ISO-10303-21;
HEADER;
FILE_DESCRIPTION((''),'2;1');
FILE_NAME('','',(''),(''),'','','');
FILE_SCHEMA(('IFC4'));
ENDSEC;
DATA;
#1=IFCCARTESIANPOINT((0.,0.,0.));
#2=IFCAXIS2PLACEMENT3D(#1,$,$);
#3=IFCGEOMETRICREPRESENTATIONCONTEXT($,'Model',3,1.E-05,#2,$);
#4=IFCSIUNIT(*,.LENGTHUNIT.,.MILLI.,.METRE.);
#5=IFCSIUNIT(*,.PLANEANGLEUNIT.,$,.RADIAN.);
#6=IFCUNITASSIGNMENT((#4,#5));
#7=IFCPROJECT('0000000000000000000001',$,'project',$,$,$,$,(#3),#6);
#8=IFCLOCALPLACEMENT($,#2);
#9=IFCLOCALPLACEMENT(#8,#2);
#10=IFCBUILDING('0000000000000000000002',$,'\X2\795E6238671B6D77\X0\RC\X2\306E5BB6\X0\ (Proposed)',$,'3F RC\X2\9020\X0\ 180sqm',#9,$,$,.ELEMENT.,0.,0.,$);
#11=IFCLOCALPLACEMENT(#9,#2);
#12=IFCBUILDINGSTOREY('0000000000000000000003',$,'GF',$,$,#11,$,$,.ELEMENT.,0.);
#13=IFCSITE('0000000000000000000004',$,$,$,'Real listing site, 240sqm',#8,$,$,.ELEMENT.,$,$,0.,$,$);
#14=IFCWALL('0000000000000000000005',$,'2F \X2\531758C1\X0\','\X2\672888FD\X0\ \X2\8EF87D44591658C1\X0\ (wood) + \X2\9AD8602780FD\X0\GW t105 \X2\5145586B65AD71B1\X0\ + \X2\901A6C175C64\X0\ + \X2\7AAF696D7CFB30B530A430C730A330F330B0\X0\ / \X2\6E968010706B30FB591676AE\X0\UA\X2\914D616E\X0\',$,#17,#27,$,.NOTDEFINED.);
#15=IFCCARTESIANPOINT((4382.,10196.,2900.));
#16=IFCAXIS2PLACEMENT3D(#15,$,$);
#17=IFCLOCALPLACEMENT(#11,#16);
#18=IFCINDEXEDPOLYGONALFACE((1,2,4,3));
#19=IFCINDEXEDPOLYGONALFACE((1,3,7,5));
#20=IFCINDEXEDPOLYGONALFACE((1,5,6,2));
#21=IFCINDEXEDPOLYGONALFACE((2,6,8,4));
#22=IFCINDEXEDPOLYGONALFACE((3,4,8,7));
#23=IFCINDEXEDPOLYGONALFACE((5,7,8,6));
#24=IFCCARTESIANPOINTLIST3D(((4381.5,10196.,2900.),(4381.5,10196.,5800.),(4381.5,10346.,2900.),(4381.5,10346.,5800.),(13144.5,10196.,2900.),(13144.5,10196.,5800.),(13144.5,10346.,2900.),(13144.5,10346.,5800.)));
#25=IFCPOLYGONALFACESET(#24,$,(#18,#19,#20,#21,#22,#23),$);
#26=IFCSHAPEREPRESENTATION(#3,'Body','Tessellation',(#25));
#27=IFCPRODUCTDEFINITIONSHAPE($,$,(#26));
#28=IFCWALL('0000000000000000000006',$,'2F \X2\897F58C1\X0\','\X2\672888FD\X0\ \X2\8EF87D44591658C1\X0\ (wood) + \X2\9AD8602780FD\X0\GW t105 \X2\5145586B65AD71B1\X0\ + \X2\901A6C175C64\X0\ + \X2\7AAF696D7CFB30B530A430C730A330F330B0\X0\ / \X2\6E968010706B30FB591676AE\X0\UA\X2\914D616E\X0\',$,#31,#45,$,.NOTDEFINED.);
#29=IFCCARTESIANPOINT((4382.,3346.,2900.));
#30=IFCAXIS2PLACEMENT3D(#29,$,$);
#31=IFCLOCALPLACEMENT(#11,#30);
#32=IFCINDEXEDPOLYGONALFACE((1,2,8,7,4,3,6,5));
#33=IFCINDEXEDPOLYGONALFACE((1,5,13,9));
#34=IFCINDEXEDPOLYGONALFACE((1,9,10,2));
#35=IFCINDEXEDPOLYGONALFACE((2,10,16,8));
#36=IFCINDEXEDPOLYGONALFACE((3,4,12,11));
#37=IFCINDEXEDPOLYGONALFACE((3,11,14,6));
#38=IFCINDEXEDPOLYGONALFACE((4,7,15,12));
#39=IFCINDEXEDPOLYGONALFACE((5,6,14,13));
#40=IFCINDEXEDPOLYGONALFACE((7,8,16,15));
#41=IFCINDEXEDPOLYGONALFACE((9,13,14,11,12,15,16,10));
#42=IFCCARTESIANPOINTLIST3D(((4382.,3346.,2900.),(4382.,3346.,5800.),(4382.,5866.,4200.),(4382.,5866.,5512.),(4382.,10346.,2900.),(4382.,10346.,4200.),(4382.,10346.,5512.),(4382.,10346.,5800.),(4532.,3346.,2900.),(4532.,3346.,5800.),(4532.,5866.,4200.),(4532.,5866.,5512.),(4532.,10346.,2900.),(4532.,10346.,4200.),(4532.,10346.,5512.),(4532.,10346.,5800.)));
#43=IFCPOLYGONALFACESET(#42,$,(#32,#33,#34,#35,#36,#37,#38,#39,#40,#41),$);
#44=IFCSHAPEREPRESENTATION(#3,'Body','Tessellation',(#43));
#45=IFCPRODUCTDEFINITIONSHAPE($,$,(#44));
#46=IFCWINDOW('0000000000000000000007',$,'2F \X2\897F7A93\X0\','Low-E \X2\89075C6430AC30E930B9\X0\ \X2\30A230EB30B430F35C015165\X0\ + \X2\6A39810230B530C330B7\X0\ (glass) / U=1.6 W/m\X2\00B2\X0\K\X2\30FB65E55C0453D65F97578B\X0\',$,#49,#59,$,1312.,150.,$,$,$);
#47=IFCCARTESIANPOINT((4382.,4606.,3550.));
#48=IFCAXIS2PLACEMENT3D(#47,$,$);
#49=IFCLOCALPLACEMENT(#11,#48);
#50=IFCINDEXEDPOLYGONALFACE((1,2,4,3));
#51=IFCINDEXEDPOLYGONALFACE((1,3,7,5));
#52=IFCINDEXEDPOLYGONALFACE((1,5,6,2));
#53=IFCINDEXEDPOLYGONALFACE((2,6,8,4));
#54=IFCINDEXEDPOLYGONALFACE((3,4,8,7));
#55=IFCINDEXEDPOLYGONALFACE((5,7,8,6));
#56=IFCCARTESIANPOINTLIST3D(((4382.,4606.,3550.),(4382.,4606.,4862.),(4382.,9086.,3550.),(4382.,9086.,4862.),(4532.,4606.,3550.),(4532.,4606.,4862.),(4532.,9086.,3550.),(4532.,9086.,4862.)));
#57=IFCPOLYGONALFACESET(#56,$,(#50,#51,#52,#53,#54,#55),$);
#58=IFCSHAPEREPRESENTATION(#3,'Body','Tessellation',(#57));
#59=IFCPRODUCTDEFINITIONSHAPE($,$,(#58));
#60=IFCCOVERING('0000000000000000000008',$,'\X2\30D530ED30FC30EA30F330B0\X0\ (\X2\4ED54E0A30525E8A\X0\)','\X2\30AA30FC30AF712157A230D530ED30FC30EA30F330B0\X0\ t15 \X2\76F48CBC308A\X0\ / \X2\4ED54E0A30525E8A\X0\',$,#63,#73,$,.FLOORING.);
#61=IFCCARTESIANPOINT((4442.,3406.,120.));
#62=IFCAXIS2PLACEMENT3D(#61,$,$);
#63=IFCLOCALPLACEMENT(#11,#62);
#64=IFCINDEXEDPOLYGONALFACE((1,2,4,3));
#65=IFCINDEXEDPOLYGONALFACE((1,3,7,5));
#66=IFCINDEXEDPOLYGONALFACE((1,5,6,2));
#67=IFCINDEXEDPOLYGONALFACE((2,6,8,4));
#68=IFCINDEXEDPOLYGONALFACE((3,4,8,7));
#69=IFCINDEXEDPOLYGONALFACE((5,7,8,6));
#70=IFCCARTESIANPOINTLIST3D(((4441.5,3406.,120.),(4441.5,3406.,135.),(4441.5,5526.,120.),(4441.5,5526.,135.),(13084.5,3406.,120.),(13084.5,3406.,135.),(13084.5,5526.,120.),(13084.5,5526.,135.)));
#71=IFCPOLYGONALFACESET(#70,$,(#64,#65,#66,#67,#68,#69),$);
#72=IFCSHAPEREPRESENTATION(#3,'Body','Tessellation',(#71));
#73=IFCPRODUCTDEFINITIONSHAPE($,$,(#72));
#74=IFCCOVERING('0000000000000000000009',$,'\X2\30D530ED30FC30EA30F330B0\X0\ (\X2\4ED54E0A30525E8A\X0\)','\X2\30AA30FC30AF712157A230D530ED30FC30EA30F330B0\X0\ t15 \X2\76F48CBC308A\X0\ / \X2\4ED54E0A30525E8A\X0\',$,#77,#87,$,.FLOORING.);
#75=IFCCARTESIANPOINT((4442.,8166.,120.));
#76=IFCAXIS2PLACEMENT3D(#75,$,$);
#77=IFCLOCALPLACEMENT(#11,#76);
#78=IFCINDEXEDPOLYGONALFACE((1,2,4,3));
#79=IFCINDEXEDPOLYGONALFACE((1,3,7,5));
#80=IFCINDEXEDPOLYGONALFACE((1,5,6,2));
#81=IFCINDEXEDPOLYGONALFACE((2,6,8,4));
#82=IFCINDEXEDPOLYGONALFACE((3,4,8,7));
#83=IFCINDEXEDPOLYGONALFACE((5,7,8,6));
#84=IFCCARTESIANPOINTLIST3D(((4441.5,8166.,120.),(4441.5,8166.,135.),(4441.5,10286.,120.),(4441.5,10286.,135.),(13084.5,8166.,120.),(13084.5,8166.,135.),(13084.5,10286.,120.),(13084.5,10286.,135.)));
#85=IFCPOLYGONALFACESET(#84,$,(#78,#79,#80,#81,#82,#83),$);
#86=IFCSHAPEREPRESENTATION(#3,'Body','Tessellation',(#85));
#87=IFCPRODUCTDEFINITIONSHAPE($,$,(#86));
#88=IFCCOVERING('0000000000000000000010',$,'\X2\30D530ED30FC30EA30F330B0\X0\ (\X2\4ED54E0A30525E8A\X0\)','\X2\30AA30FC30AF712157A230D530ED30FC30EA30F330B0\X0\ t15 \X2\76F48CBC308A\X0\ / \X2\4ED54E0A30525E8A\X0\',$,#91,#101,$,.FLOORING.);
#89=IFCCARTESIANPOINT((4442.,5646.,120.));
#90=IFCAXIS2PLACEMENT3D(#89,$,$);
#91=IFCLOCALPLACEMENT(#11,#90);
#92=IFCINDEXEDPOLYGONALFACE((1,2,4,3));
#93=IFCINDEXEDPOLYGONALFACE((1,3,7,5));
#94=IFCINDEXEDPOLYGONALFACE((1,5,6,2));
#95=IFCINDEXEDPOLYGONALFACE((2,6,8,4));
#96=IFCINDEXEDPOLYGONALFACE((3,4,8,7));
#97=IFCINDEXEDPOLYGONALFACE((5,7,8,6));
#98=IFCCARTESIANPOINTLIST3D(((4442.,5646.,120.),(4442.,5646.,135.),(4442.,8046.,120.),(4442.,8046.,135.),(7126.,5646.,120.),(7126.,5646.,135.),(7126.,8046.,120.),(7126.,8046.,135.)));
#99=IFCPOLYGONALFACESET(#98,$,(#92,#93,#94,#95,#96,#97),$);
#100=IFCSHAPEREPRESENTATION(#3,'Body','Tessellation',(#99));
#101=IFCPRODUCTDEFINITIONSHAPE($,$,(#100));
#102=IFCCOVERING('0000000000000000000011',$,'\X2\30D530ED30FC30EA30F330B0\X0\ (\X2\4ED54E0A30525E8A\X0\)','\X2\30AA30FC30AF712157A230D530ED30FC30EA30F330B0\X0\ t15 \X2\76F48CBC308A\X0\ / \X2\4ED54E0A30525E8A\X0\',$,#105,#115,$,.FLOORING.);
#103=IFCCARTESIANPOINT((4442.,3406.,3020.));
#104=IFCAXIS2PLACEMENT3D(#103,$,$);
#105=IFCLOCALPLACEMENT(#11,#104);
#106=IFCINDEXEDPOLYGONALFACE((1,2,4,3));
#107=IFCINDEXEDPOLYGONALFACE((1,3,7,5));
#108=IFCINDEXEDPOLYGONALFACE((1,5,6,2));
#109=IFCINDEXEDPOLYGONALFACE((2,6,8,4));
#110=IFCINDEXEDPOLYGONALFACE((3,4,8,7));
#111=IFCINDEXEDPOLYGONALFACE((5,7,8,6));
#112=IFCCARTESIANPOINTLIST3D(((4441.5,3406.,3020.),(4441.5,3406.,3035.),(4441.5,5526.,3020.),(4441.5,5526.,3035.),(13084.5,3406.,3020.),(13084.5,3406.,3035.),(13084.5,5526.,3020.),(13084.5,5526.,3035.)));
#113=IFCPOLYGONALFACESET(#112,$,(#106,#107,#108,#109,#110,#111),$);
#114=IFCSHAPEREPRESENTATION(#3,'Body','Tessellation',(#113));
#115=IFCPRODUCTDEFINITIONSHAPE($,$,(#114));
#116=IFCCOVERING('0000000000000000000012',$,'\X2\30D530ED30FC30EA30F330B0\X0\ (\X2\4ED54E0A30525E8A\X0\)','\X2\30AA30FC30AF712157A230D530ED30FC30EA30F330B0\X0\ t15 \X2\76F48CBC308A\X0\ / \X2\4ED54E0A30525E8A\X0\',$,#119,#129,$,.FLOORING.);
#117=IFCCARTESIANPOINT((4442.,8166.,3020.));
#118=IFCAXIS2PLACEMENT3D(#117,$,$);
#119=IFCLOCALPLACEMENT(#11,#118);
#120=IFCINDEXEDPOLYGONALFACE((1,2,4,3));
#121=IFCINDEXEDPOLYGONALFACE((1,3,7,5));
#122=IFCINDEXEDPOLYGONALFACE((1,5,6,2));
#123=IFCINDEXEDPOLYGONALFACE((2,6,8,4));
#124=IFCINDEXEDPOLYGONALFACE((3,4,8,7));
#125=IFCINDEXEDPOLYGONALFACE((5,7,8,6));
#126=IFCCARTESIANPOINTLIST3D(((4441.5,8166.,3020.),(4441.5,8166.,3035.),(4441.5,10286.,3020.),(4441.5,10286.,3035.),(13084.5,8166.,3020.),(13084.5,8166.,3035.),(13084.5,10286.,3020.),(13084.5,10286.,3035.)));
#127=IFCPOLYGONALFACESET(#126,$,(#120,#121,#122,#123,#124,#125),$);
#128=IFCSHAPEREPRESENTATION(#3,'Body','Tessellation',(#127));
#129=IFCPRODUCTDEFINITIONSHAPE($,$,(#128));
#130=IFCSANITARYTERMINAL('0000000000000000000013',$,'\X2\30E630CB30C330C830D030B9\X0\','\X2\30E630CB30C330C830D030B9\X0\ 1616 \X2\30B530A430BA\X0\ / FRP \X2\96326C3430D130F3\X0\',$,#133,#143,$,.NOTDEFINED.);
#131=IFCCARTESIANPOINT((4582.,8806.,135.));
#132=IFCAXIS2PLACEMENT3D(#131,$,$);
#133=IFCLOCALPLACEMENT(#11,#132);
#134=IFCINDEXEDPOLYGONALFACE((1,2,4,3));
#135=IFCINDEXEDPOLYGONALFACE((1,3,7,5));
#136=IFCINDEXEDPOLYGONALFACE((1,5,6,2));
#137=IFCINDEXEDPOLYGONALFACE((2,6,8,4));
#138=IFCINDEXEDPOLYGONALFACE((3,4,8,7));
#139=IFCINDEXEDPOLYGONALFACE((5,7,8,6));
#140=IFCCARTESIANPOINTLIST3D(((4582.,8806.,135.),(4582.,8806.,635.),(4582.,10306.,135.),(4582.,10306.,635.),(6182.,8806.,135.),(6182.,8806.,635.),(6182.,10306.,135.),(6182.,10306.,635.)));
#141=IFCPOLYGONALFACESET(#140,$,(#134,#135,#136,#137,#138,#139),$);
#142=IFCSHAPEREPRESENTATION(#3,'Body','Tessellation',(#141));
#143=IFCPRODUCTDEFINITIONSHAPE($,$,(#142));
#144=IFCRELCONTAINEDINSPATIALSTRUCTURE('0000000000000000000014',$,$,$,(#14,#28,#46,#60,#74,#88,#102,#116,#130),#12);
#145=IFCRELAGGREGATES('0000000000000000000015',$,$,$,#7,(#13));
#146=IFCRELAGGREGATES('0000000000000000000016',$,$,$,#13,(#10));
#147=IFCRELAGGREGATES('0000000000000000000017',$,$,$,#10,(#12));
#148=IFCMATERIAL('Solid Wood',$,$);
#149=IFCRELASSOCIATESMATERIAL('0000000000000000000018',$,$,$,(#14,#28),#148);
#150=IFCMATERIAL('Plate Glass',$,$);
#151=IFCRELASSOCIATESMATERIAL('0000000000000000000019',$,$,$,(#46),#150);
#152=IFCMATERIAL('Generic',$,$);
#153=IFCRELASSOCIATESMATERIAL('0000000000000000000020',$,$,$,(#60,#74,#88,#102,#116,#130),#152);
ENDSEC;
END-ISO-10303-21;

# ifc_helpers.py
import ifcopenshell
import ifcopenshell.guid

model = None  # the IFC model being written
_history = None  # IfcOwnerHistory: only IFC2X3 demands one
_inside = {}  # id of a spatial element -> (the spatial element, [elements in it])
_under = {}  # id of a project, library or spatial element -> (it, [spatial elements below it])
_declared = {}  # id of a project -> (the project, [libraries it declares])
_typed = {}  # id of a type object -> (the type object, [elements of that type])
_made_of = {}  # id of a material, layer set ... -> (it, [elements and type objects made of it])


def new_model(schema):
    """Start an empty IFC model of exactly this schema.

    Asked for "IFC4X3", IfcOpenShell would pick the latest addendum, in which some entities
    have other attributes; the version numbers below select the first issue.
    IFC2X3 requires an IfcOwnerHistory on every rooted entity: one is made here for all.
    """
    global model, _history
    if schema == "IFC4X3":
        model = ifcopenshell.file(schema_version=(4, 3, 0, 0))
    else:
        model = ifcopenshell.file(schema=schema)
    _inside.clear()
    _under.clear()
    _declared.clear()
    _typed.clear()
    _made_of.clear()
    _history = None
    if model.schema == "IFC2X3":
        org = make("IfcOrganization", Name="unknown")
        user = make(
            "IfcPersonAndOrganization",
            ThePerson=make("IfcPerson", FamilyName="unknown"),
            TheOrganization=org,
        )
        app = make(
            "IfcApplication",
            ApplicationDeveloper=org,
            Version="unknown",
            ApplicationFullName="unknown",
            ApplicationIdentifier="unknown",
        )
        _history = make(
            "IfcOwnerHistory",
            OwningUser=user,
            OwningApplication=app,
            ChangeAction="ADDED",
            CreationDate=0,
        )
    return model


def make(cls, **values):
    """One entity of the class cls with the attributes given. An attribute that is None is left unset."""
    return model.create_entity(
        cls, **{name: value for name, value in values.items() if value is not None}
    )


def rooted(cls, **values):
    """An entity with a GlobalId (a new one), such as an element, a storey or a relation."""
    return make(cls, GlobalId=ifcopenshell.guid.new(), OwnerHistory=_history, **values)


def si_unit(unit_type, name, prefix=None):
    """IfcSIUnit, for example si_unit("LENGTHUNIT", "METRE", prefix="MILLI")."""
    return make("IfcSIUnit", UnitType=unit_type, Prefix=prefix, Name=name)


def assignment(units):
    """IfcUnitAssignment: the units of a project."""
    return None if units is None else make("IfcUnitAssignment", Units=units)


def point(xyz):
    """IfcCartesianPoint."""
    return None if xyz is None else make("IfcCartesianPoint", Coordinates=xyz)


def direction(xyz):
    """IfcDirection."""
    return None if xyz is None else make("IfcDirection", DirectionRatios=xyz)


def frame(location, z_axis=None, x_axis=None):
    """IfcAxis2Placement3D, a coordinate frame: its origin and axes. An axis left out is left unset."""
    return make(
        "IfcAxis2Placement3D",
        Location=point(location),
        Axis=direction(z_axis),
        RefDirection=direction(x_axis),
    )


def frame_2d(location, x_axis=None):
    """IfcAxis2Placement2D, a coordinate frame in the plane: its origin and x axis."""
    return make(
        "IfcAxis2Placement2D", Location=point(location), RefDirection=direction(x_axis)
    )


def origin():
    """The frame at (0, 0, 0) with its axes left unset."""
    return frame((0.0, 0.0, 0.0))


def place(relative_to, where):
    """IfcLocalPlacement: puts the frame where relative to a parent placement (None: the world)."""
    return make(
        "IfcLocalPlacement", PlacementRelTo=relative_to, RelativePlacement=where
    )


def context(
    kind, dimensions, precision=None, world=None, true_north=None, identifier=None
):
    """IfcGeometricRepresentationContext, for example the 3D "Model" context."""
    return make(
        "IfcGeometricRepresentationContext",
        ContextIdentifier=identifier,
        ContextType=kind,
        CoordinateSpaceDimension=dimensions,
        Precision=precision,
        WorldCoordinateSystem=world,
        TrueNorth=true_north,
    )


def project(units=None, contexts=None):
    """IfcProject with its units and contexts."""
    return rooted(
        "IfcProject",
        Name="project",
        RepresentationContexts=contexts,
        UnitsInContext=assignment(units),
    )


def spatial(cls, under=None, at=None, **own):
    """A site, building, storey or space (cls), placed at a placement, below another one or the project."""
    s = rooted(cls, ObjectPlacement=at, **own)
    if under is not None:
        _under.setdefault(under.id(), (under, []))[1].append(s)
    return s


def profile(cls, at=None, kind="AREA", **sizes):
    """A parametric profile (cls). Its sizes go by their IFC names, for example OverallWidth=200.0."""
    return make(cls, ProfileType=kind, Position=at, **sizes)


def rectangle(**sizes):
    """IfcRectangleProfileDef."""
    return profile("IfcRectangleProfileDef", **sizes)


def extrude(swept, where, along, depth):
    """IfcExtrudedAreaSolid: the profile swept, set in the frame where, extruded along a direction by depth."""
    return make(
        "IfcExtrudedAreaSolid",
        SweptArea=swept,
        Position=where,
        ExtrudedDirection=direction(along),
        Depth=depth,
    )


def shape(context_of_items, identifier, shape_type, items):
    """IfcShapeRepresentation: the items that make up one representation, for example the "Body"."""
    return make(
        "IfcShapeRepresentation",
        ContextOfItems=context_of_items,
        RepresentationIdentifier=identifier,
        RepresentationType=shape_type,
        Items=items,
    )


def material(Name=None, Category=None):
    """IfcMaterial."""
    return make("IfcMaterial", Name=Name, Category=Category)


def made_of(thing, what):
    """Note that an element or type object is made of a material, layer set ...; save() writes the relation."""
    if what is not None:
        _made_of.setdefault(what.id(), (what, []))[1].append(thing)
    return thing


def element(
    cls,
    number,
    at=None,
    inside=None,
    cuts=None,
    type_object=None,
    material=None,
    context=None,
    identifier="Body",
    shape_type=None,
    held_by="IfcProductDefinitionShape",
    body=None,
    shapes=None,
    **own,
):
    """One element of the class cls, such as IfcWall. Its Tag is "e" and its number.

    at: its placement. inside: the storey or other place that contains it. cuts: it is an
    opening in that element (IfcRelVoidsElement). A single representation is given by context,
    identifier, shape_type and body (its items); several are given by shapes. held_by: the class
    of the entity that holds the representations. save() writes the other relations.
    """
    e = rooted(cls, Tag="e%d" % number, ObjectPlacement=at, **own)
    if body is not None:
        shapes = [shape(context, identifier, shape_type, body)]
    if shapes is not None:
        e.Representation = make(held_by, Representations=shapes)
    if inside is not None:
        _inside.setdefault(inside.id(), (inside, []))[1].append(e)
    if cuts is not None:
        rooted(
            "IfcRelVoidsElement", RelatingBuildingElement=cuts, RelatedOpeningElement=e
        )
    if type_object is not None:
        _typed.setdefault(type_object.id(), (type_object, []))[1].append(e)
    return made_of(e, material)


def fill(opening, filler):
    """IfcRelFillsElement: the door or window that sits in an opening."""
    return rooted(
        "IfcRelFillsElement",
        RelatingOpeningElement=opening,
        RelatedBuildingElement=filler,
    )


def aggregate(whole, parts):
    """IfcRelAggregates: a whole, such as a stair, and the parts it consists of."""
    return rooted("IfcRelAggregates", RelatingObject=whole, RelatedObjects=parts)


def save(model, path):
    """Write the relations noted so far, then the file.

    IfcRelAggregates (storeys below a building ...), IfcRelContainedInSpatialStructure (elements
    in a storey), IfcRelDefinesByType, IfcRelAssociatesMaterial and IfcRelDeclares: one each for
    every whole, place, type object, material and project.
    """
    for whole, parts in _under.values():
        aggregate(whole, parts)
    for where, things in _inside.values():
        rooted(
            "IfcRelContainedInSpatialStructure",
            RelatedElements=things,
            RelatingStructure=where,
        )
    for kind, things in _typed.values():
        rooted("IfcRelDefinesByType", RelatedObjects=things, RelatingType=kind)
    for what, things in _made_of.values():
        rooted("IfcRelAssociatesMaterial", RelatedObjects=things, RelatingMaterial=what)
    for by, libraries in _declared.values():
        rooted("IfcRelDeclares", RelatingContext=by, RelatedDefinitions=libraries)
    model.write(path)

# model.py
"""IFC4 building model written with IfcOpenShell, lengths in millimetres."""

from ifc_helpers import new_model, si_unit, frame, frame_2d, origin, place, context, project, spatial, rectangle, extrude, material, element, fill, save


model = new_model("IFC4")

# Units and contexts
model_context = context("Model", 3, precision=1e-05, world=origin())
ifc_project = project(units=[si_unit("LENGTHUNIT", "METRE", prefix="MILLI"), si_unit("PLANEANGLEUNIT", "RADIAN")], contexts=[model_context])

# Site, building, storey
site_placement = place(None, origin())
site = spatial("IfcSite", under=ifc_project, at=site_placement, ObjectType="Real listing site, 240sqm", CompositionType="ELEMENT", RefElevation=0.0)
building_placement = place(site_placement, origin())
building = spatial("IfcBuilding", under=site, at=building_placement, Name="神戸望海RCの家 (Proposed)", ObjectType="3F RC造 180sqm", CompositionType="ELEMENT", ElevationOfRefHeight=0.0, ElevationOfTerrain=0.0)
storey_placement = place(building_placement, origin())
storey = spatial("IfcBuildingStorey", under=building, at=storey_placement, Name="GF", CompositionType="ELEMENT", Elevation=0.0)

# Shared definitions
ifc_material_1 = material(Name="Solid Wood")

# Shared definitions
ifc_material_2 = material(Name="Plate Glass")

# Wall
wall_1_placement = place(storey_placement, frame((4382.0, 10196.0, 2900.0)))
element("IfcWall", 1, at=wall_1_placement, inside=storey, material=ifc_material_1, Name="2F 北壁", Description="木製 軸組外壁 (wood) + 高性能GW t105 充填断熱 + 通気層 + 窯業系サイディング / 準耐火・外皮UA配慮", PredefinedType="NOTDEFINED", context=model_context, shape_type="SweptSolid", body=[
    extrude(rectangle(XDim=8763.0, YDim=150.0, at=frame_2d((4381.0, 75.0))), frame((4382.0, 10196.0, 2900.0)), (0.0, 0.0, 1.0), 2900.0),
])

# Wall, opening, window
wall_2_placement = place(storey_placement, frame((4382.0, 3346.0, 2900.0)))
wall_2 = element("IfcWall", 2, at=wall_2_placement, inside=storey, material=ifc_material_1, Name="2F 西壁", Description="木製 軸組外壁 (wood) + 高性能GW t105 充填断熱 + 通気層 + 窯業系サイディング / 準耐火・外皮UA配慮", PredefinedType="NOTDEFINED", context=model_context, shape_type="SweptSolid", body=[
    extrude(rectangle(XDim=150.0, YDim=7000.0, at=frame_2d((75.0, 3500.0))), frame((4382.0, 3346.0, 2900.0)), (0.0, 0.0, 1.0), 2900.0),
])
opening_1_placement = place(storey_placement, frame((4382.0, 4606.0, 3550.0)))
opening_1 = element("IfcOpeningElement", 3, at=opening_1_placement, cuts=wall_2, PredefinedType="NOTDEFINED", context=model_context, shape_type="SweptSolid", body=[
    extrude(rectangle(XDim=150.0, YDim=4480.0, at=frame_2d((75.0, 2240.0))), frame((4382.0, 4606.0, 3550.0)), (0.0, 0.0, 1.0), 1312.0),
])
window_1_placement = place(storey_placement, frame((4382.0, 4606.0, 3550.0)))
window_1 = element("IfcWindow", 4, at=window_1_placement, inside=storey, material=ifc_material_2, Name="2F 西窓", Description="Low-E 複層ガラス アルゴン封入 + 樹脂サッシ (glass) / U=1.6 W/m²K・日射取得型", OverallHeight=1312.0, OverallWidth=150.0, context=model_context, shape_type="SweptSolid", body=[
    extrude(rectangle(XDim=150.0, YDim=4480.0, at=frame_2d((75.0, 2240.0))), frame((4382.0, 4606.0, 3550.0)), (0.0, 0.0, 1.0), 1312.0),
])
fill(opening_1, window_1)

# Coverings
ifc_material_3 = material(Name="Generic")
covering_1_placement = place(storey_placement, frame((4442.0, 3406.0, 120.0)))
element("IfcCovering", 5, at=covering_1_placement, inside=storey, material=ifc_material_3, Name="フローリング (仕上げ床)", Description="オーク無垢フローリング t15 直貼り / 仕上げ床", PredefinedType="FLOORING", context=model_context, shape_type="SweptSolid", body=[
    extrude(rectangle(XDim=8643.0, YDim=2120.0, at=frame_2d((4321.0, 1060.0))), frame((4442.0, 3406.0, 120.0)), (0.0, 0.0, 1.0), 15.0),
])
covering_2_placement = place(storey_placement, frame((4442.0, 8166.0, 120.0)))
element("IfcCovering", 6, at=covering_2_placement, inside=storey, material=ifc_material_3, Name="フローリング (仕上げ床)", Description="オーク無垢フローリング t15 直貼り / 仕上げ床", PredefinedType="FLOORING", context=model_context, shape_type="SweptSolid", body=[
    extrude(rectangle(XDim=8643.0, YDim=2120.0, at=frame_2d((4321.0, 1060.0))), frame((4442.0, 8166.0, 120.0)), (0.0, 0.0, 1.0), 15.0),
])
covering_3_placement = place(storey_placement, frame((4442.0, 5646.0, 120.0)))
element("IfcCovering", 7, at=covering_3_placement, inside=storey, material=ifc_material_3, Name="フローリング (仕上げ床)", Description="オーク無垢フローリング t15 直貼り / 仕上げ床", PredefinedType="FLOORING", context=model_context, shape_type="SweptSolid", body=[
    extrude(rectangle(XDim=2684.0, YDim=2400.0, at=frame_2d((1342.0, 1200.0))), frame((4442.0, 5646.0, 120.0)), (0.0, 0.0, 1.0), 15.0),
])
covering_4_placement = place(storey_placement, frame((4442.0, 3406.0, 3020.0)))
element("IfcCovering", 8, at=covering_4_placement, inside=storey, material=ifc_material_3, Name="フローリング (仕上げ床)", Description="オーク無垢フローリング t15 直貼り / 仕上げ床", PredefinedType="FLOORING", context=model_context, shape_type="SweptSolid", body=[
    extrude(rectangle(XDim=8643.0, YDim=2120.0, at=frame_2d((4321.0, 1060.0))), frame((4442.0, 3406.0, 3020.0)), (0.0, 0.0, 1.0), 15.0),
])
covering_5_placement = place(storey_placement, frame((4442.0, 8166.0, 3020.0)))
element("IfcCovering", 9, at=covering_5_placement, inside=storey, material=ifc_material_3, Name="フローリング (仕上げ床)", Description="オーク無垢フローリング t15 直貼り / 仕上げ床", PredefinedType="FLOORING", context=model_context, shape_type="SweptSolid", body=[
    extrude(rectangle(XDim=8643.0, YDim=2120.0, at=frame_2d((4321.0, 1060.0))), frame((4442.0, 8166.0, 3020.0)), (0.0, 0.0, 1.0), 15.0),
])

# Sanitary terminal
sanitary_terminal_placement = place(storey_placement, frame((4582.0, 8806.0, 135.0)))
element("IfcSanitaryTerminal", 10, at=sanitary_terminal_placement, inside=storey, material=ifc_material_3, Name="ユニットバス", Description="ユニットバス 1616 サイズ / FRP 防水パン", PredefinedType="NOTDEFINED", context=model_context, shape_type="SweptSolid", body=[
    extrude(rectangle(XDim=1600.0, YDim=1500.0, at=frame_2d((800.0, 750.0))), frame((4582.0, 8806.0, 135.0)), (0.0, 0.0, 1.0), 500.0),
])

save(model, "model.ifc")
